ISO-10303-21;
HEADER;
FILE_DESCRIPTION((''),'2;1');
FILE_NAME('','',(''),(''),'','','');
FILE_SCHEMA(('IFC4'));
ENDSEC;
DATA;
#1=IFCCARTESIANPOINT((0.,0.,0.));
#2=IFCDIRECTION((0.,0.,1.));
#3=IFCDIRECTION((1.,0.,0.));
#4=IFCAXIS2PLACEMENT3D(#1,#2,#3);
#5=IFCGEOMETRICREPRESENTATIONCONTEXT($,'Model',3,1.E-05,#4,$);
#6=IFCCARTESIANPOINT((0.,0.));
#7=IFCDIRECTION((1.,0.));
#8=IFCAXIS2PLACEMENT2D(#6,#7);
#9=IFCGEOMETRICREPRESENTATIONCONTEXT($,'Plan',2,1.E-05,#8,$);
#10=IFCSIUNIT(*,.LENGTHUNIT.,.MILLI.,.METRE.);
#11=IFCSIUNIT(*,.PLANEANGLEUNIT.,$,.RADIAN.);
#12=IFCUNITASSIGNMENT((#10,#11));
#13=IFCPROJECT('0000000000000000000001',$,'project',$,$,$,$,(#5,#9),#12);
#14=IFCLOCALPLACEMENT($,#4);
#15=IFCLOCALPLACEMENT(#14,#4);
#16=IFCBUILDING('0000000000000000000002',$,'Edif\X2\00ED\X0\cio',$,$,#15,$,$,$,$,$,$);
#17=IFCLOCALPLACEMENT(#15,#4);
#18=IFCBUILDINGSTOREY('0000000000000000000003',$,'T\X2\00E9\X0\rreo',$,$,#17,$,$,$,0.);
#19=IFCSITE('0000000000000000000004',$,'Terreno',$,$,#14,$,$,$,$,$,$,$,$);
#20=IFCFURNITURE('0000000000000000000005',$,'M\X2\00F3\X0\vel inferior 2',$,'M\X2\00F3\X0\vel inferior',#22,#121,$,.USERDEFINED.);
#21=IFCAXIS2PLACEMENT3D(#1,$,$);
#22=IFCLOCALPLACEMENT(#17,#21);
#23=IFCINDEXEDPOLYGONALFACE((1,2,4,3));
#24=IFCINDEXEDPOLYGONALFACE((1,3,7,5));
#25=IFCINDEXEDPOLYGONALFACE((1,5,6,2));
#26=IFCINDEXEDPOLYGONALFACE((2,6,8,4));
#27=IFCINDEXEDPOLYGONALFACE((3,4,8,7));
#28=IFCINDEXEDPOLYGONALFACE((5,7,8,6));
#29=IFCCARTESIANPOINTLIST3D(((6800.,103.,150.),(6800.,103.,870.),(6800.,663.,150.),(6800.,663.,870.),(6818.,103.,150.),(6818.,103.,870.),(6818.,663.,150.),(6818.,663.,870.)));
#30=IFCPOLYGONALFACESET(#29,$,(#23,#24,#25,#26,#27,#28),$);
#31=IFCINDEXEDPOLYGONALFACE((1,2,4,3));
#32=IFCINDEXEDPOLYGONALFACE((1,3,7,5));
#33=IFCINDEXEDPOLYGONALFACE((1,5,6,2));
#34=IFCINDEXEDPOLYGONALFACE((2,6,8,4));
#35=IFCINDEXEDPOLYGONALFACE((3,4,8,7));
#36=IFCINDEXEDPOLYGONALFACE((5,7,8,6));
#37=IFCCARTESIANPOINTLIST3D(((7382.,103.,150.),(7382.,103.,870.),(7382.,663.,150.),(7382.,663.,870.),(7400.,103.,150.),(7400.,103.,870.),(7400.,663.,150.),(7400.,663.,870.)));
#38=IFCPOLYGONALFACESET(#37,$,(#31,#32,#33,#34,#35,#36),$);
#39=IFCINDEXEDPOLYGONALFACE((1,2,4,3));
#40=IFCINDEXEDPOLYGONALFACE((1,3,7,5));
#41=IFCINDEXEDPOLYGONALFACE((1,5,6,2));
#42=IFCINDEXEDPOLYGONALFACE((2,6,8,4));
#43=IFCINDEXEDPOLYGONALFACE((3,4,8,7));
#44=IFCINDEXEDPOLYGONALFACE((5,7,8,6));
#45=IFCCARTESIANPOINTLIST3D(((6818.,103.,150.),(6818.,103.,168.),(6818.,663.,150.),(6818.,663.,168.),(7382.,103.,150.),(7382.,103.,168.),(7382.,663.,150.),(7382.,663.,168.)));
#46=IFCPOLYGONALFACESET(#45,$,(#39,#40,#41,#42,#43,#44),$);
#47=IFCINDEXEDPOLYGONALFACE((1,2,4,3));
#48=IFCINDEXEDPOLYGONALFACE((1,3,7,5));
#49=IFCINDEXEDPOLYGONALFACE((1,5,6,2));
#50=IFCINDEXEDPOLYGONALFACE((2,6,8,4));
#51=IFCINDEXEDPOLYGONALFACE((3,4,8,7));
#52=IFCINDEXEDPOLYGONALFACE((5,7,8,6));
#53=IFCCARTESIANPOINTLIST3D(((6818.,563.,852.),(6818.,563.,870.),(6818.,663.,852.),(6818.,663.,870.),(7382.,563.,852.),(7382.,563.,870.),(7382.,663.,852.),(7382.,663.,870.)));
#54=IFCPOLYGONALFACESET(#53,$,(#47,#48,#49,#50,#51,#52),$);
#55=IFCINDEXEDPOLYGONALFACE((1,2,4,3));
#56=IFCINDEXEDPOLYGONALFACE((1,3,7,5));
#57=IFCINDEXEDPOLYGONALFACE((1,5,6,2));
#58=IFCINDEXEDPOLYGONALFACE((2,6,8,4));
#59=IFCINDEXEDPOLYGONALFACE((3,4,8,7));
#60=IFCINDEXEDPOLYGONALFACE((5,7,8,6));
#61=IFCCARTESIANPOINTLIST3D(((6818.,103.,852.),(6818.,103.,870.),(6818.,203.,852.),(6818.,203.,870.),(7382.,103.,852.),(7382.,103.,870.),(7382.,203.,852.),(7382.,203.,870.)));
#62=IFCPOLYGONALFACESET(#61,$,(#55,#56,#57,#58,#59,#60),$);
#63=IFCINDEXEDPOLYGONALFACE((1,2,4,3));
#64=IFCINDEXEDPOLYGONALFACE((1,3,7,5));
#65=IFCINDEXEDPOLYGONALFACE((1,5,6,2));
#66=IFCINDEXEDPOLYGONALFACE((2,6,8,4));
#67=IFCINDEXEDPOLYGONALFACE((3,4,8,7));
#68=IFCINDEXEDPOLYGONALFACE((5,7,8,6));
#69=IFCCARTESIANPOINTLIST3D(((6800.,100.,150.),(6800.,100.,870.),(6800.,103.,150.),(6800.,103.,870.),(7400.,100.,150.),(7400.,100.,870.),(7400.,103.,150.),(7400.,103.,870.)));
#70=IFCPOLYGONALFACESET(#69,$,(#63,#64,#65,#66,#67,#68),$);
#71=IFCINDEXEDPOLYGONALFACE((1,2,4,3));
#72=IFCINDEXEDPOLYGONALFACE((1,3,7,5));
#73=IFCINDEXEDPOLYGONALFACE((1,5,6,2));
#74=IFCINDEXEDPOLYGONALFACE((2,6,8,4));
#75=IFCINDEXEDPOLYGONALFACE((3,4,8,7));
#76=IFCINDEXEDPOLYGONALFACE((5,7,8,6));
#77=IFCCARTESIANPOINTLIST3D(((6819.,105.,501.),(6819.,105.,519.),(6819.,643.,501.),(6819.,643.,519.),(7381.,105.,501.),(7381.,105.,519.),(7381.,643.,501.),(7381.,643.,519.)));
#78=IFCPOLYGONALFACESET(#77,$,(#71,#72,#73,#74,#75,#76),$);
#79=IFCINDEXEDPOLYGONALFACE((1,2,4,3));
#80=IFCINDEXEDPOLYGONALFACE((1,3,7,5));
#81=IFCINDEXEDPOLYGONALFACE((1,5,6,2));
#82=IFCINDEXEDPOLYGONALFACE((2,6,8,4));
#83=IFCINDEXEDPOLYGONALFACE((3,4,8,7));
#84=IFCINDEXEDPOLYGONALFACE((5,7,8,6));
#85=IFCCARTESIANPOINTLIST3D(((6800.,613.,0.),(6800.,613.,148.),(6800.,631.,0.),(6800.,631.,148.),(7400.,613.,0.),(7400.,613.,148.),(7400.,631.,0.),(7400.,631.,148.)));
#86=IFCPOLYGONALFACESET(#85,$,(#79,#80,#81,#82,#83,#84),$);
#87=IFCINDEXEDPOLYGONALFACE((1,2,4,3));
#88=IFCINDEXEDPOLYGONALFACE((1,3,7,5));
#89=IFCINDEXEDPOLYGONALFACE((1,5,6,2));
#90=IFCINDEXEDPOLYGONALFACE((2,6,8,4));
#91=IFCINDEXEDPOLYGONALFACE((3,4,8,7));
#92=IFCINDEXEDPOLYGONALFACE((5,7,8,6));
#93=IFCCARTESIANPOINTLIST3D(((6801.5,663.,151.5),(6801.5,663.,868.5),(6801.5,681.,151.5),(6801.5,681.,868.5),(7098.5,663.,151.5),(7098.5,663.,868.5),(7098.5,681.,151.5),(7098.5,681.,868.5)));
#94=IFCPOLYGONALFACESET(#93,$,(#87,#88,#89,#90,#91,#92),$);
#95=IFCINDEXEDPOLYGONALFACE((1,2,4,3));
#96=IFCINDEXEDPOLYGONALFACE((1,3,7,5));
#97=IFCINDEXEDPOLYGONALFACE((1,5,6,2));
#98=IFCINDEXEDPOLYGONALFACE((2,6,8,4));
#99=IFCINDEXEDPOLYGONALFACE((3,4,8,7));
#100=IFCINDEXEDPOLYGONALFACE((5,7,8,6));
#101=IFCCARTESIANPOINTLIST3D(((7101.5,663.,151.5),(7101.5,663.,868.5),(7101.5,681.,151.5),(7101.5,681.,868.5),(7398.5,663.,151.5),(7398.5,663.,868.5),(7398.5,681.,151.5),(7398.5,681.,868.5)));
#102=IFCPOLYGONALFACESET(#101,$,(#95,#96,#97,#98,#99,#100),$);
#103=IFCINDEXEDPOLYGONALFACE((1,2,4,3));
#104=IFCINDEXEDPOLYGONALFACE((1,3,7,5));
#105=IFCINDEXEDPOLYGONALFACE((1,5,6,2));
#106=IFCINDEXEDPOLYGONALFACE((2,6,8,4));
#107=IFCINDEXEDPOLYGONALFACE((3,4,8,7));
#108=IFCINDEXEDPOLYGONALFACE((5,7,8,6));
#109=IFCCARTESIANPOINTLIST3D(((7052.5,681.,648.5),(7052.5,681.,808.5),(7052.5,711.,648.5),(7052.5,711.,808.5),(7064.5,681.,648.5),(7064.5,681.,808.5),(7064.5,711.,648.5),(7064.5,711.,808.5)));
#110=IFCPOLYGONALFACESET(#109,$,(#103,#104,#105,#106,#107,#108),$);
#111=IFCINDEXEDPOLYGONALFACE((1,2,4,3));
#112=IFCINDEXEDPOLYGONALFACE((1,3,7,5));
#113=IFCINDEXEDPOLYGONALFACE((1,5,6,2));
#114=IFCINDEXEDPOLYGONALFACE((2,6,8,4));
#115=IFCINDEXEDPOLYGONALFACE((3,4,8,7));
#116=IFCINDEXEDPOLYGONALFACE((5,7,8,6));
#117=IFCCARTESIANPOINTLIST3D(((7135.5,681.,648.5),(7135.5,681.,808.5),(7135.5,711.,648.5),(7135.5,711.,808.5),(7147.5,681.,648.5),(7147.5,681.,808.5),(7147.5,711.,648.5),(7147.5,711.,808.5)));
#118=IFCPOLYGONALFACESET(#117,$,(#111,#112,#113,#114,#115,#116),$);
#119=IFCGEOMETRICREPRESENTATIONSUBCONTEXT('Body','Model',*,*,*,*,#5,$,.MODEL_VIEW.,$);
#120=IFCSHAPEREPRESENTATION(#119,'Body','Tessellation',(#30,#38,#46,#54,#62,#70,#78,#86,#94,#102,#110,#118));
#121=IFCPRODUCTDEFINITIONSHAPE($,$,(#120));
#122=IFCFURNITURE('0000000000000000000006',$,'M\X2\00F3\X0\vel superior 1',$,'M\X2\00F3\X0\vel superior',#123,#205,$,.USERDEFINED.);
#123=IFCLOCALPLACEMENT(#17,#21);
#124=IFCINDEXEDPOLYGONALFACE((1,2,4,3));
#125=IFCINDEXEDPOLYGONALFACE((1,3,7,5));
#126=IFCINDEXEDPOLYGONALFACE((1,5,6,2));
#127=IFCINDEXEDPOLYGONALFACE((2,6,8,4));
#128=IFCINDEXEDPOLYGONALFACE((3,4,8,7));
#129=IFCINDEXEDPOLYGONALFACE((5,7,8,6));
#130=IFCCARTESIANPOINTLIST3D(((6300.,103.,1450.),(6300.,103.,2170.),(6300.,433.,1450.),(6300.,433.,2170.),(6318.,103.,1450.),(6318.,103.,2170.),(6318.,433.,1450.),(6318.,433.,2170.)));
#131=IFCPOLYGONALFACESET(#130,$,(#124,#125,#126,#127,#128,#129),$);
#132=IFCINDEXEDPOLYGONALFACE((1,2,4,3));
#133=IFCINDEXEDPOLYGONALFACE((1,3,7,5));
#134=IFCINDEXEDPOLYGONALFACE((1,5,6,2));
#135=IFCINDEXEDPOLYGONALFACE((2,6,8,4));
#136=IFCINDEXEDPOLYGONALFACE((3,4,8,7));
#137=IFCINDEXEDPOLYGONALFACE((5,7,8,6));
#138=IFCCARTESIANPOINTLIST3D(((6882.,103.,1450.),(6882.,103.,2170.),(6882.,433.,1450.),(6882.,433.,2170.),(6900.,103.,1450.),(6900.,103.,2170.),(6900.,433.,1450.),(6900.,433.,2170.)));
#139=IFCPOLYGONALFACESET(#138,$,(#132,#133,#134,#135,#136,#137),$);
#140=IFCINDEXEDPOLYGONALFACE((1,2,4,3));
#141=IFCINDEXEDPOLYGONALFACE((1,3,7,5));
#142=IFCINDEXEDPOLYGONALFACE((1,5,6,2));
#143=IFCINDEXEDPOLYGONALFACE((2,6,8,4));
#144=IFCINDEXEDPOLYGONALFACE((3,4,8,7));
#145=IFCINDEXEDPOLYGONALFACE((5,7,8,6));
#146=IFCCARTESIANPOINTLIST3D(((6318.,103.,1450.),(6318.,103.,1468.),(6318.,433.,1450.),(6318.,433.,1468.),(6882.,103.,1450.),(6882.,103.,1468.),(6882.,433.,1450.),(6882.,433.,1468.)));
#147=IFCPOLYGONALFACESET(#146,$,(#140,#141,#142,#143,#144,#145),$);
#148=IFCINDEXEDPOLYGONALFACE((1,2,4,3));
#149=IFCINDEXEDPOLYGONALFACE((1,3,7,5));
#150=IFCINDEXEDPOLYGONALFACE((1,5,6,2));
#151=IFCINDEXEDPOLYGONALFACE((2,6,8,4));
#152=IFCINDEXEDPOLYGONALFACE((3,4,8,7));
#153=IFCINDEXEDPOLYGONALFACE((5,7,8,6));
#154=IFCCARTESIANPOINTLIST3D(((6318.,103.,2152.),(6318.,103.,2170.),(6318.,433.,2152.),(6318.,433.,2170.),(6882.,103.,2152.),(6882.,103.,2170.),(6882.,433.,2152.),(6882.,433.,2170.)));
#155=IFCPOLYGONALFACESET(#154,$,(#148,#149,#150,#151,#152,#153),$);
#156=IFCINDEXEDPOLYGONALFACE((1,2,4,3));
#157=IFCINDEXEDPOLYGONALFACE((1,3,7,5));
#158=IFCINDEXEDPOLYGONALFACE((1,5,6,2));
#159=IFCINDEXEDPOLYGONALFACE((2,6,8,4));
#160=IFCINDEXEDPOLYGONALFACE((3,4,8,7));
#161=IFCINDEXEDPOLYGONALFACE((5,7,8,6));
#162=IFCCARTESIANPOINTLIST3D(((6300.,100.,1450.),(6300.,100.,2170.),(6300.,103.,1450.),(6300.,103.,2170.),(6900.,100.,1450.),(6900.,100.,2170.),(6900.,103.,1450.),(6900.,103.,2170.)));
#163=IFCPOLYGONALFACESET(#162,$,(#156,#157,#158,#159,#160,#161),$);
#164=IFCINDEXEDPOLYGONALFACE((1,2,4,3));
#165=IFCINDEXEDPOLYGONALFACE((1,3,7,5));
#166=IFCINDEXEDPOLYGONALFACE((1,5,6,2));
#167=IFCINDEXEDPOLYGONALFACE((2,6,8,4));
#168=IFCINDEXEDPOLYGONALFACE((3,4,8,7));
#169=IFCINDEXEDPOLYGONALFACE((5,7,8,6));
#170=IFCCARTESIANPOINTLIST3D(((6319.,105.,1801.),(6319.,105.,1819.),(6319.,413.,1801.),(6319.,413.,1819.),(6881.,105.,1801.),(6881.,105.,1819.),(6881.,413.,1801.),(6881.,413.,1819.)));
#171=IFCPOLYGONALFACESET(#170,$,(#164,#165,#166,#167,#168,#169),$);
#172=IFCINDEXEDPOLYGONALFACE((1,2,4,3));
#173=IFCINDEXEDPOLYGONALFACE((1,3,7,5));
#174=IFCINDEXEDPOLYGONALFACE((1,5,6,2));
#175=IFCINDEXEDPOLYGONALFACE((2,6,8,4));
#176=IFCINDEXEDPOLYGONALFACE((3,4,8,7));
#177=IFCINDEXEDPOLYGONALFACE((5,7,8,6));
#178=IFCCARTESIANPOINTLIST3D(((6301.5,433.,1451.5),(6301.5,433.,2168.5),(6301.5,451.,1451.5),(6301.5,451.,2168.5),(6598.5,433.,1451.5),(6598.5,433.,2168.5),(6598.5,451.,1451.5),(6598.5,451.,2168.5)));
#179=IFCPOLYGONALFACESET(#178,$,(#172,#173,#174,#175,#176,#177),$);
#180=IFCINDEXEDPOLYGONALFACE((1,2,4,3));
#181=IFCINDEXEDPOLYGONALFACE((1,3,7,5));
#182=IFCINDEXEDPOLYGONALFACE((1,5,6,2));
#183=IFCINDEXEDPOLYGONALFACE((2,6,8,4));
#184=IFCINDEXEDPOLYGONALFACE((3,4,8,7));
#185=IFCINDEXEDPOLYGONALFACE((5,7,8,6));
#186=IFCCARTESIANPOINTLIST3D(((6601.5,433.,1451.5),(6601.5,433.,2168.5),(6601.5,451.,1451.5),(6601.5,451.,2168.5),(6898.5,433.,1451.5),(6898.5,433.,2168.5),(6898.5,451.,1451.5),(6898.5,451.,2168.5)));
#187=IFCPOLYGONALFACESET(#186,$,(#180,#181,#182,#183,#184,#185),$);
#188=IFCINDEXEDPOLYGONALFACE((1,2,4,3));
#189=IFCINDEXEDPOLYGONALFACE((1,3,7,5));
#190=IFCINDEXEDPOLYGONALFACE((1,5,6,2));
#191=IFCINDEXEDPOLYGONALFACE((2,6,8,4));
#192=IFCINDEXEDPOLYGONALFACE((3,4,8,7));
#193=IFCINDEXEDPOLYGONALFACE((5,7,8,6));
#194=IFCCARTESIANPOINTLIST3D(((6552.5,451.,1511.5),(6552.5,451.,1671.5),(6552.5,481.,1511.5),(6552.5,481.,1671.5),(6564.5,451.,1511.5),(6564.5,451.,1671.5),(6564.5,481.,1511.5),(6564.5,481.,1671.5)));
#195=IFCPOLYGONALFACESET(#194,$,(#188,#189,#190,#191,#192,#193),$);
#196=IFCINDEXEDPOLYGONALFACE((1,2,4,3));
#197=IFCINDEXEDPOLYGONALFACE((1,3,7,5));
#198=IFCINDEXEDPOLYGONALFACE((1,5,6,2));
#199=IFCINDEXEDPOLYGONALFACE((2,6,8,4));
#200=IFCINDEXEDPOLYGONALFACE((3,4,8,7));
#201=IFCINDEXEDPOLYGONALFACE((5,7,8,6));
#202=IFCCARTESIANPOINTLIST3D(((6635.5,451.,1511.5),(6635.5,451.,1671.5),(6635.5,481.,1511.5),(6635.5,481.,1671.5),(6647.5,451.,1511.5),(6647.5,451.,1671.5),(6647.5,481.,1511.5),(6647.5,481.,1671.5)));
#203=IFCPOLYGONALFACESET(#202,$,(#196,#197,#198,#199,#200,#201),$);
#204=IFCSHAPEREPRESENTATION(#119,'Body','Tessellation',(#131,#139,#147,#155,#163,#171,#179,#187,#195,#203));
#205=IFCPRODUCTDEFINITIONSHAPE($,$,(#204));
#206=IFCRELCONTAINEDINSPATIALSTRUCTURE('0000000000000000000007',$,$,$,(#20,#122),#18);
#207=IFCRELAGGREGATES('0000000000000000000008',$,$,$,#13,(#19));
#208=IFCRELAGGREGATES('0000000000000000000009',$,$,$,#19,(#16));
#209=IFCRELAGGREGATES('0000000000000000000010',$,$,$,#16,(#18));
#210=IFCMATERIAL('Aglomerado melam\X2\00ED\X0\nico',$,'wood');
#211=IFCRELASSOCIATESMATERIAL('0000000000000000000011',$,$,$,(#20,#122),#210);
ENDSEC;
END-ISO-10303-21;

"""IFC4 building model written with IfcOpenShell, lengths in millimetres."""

from ifc_helpers import new_model, si_unit, frame, frame_2d, origin, origin_with_axes, origin_2d_with_axis, place, context, subcontext, project, spatial, rectangle, extrude, material, element, save


model = new_model("IFC4")

# Units and contexts
model_context = context("Model", 3, precision=1e-05, world=origin_with_axes())
plan_context = context("Plan", 2, precision=1e-05, world=origin_2d_with_axis())
body_context = subcontext(model_context, "Body", "Model", "MODEL_VIEW")
ifc_project = project(units=[si_unit("LENGTHUNIT", "METRE", prefix="MILLI"), si_unit("PLANEANGLEUNIT", "RADIAN")], contexts=[model_context, plan_context])

# Site, building, storey
site_placement = place(None, origin_with_axes())
site = spatial("IfcSite", under=ifc_project, at=site_placement, Name="Terreno")
building_placement = place(site_placement, origin_with_axes())
building = spatial("IfcBuilding", under=site, at=building_placement, Name="Edifício")
storey_placement = place(building_placement, origin_with_axes())
storey = spatial("IfcBuildingStorey", under=building, at=storey_placement, Name="Térreo", Elevation=0.0)

# Furniture
ifc_material_1 = material(Name="Aglomerado melamínico", Category="wood")
furniture_1_placement = place(storey_placement, frame((6800.0, 100.0, 0.0), z_axis=(0.0, 0.0, 1.0), x_axis=(1.0, 0.0, 0.0)))
element("IfcFurniture", 1, at=furniture_1_placement, inside=storey, material=ifc_material_1, Name="Móvel inferior 2", ObjectType="Móvel inferior", PredefinedType="USERDEFINED", context=body_context, shape_type="SweptSolid", body=[
    extrude(rectangle(XDim=18.0, YDim=560.0, at=frame_2d((9.0, 283.0))), frame((0.0, 0.0, 150.0)), (0.0, 0.0, 1.0), 720.0),
    extrude(rectangle(XDim=18.0, YDim=560.0, at=frame_2d((591.0, 283.0))), frame((0.0, 0.0, 150.0)), (0.0, 0.0, 1.0), 720.0),
    extrude(rectangle(XDim=564.0, YDim=560.0, at=frame_2d((300.0, 283.0))), frame((0.0, 0.0, 150.0)), (0.0, 0.0, 1.0), 18.0),
    extrude(rectangle(XDim=564.0, YDim=100.0, at=frame_2d((300.0, 513.0))), frame((0.0, 0.0, 852.0)), (0.0, 0.0, 1.0), 18.0),
    extrude(rectangle(XDim=564.0, YDim=100.0, at=frame_2d((300.0, 53.0))), frame((0.0, 0.0, 852.0)), (0.0, 0.0, 1.0), 18.0),
    extrude(rectangle(XDim=600.0, YDim=3.0, at=frame_2d((300.0, 1.5))), frame((0.0, 0.0, 150.0)), (0.0, 0.0, 1.0), 720.0),
    extrude(rectangle(XDim=562.0, YDim=538.0, at=frame_2d((300.0, 274.0))), frame((0.0, 0.0, 501.0)), (0.0, 0.0, 1.0), 18.0),
    extrude(rectangle(XDim=600.0, YDim=18.0, at=frame_2d((300.0, 522.0))), origin(), (0.0, 0.0, 1.0), 148.0),
    extrude(rectangle(XDim=297.0, YDim=18.0, at=frame_2d((150.0, 572.0))), frame((0.0, 0.0, 151.5)), (0.0, 0.0, 1.0), 717.0),
    extrude(rectangle(XDim=297.0, YDim=18.0, at=frame_2d((450.0, 572.0))), frame((0.0, 0.0, 151.5)), (0.0, 0.0, 1.0), 717.0),
    extrude(rectangle(XDim=12.0, YDim=30.0, at=frame_2d((258.5, 596.0))), frame((0.0, 0.0, 648.5)), (0.0, 0.0, 1.0), 160.0),
    extrude(rectangle(XDim=12.0, YDim=30.0, at=frame_2d((341.5, 596.0))), frame((0.0, 0.0, 648.5)), (0.0, 0.0, 1.0), 160.0),
])
for number, where, z_axis, x_axis, name in (
    (2, (6300.0, 100.0, 0.0), (0.0, 0.0, 1.0), (1.0, 0.0, 0.0), "Móvel superior 1"),
):
    element("IfcFurniture", number, at=place(storey_placement, frame(where, z_axis=z_axis, x_axis=x_axis)), inside=storey, material=ifc_material_1, Name=name, ObjectType="Móvel superior", PredefinedType="USERDEFINED", context=body_context, shape_type="SweptSolid", body=[
        extrude(rectangle(XDim=18.0, YDim=330.0, at=frame_2d((9.0, 168.0))), frame((0.0, 0.0, 1450.0)), (0.0, 0.0, 1.0), 720.0),
        extrude(rectangle(XDim=18.0, YDim=330.0, at=frame_2d((591.0, 168.0))), frame((0.0, 0.0, 1450.0)), (0.0, 0.0, 1.0), 720.0),
        extrude(rectangle(XDim=564.0, YDim=330.0, at=frame_2d((300.0, 168.0))), frame((0.0, 0.0, 1450.0)), (0.0, 0.0, 1.0), 18.0),
        extrude(rectangle(XDim=564.0, YDim=330.0, at=frame_2d((300.0, 168.0))), frame((0.0, 0.0, 2152.0)), (0.0, 0.0, 1.0), 18.0),
        extrude(rectangle(XDim=600.0, YDim=3.0, at=frame_2d((300.0, 1.5))), frame((0.0, 0.0, 1450.0)), (0.0, 0.0, 1.0), 720.0),
        extrude(rectangle(XDim=562.0, YDim=308.0, at=frame_2d((300.0, 159.0))), frame((0.0, 0.0, 1801.0)), (0.0, 0.0, 1.0), 18.0),
        extrude(rectangle(XDim=297.0, YDim=18.0, at=frame_2d((150.0, 342.0))), frame((0.0, 0.0, 1451.5)), (0.0, 0.0, 1.0), 717.0),
        extrude(rectangle(XDim=297.0, YDim=18.0, at=frame_2d((450.0, 342.0))), frame((0.0, 0.0, 1451.5)), (0.0, 0.0, 1.0), 717.0),
        extrude(rectangle(XDim=12.0, YDim=30.0, at=frame_2d((258.5, 366.0))), frame((0.0, 0.0, 1511.5)), (0.0, 0.0, 1.0), 160.0),
        extrude(rectangle(XDim=12.0, YDim=30.0, at=frame_2d((341.5, 366.0))), frame((0.0, 0.0, 1511.5)), (0.0, 0.0, 1.0), 160.0),
    ])

save(model, "model.ifc")
